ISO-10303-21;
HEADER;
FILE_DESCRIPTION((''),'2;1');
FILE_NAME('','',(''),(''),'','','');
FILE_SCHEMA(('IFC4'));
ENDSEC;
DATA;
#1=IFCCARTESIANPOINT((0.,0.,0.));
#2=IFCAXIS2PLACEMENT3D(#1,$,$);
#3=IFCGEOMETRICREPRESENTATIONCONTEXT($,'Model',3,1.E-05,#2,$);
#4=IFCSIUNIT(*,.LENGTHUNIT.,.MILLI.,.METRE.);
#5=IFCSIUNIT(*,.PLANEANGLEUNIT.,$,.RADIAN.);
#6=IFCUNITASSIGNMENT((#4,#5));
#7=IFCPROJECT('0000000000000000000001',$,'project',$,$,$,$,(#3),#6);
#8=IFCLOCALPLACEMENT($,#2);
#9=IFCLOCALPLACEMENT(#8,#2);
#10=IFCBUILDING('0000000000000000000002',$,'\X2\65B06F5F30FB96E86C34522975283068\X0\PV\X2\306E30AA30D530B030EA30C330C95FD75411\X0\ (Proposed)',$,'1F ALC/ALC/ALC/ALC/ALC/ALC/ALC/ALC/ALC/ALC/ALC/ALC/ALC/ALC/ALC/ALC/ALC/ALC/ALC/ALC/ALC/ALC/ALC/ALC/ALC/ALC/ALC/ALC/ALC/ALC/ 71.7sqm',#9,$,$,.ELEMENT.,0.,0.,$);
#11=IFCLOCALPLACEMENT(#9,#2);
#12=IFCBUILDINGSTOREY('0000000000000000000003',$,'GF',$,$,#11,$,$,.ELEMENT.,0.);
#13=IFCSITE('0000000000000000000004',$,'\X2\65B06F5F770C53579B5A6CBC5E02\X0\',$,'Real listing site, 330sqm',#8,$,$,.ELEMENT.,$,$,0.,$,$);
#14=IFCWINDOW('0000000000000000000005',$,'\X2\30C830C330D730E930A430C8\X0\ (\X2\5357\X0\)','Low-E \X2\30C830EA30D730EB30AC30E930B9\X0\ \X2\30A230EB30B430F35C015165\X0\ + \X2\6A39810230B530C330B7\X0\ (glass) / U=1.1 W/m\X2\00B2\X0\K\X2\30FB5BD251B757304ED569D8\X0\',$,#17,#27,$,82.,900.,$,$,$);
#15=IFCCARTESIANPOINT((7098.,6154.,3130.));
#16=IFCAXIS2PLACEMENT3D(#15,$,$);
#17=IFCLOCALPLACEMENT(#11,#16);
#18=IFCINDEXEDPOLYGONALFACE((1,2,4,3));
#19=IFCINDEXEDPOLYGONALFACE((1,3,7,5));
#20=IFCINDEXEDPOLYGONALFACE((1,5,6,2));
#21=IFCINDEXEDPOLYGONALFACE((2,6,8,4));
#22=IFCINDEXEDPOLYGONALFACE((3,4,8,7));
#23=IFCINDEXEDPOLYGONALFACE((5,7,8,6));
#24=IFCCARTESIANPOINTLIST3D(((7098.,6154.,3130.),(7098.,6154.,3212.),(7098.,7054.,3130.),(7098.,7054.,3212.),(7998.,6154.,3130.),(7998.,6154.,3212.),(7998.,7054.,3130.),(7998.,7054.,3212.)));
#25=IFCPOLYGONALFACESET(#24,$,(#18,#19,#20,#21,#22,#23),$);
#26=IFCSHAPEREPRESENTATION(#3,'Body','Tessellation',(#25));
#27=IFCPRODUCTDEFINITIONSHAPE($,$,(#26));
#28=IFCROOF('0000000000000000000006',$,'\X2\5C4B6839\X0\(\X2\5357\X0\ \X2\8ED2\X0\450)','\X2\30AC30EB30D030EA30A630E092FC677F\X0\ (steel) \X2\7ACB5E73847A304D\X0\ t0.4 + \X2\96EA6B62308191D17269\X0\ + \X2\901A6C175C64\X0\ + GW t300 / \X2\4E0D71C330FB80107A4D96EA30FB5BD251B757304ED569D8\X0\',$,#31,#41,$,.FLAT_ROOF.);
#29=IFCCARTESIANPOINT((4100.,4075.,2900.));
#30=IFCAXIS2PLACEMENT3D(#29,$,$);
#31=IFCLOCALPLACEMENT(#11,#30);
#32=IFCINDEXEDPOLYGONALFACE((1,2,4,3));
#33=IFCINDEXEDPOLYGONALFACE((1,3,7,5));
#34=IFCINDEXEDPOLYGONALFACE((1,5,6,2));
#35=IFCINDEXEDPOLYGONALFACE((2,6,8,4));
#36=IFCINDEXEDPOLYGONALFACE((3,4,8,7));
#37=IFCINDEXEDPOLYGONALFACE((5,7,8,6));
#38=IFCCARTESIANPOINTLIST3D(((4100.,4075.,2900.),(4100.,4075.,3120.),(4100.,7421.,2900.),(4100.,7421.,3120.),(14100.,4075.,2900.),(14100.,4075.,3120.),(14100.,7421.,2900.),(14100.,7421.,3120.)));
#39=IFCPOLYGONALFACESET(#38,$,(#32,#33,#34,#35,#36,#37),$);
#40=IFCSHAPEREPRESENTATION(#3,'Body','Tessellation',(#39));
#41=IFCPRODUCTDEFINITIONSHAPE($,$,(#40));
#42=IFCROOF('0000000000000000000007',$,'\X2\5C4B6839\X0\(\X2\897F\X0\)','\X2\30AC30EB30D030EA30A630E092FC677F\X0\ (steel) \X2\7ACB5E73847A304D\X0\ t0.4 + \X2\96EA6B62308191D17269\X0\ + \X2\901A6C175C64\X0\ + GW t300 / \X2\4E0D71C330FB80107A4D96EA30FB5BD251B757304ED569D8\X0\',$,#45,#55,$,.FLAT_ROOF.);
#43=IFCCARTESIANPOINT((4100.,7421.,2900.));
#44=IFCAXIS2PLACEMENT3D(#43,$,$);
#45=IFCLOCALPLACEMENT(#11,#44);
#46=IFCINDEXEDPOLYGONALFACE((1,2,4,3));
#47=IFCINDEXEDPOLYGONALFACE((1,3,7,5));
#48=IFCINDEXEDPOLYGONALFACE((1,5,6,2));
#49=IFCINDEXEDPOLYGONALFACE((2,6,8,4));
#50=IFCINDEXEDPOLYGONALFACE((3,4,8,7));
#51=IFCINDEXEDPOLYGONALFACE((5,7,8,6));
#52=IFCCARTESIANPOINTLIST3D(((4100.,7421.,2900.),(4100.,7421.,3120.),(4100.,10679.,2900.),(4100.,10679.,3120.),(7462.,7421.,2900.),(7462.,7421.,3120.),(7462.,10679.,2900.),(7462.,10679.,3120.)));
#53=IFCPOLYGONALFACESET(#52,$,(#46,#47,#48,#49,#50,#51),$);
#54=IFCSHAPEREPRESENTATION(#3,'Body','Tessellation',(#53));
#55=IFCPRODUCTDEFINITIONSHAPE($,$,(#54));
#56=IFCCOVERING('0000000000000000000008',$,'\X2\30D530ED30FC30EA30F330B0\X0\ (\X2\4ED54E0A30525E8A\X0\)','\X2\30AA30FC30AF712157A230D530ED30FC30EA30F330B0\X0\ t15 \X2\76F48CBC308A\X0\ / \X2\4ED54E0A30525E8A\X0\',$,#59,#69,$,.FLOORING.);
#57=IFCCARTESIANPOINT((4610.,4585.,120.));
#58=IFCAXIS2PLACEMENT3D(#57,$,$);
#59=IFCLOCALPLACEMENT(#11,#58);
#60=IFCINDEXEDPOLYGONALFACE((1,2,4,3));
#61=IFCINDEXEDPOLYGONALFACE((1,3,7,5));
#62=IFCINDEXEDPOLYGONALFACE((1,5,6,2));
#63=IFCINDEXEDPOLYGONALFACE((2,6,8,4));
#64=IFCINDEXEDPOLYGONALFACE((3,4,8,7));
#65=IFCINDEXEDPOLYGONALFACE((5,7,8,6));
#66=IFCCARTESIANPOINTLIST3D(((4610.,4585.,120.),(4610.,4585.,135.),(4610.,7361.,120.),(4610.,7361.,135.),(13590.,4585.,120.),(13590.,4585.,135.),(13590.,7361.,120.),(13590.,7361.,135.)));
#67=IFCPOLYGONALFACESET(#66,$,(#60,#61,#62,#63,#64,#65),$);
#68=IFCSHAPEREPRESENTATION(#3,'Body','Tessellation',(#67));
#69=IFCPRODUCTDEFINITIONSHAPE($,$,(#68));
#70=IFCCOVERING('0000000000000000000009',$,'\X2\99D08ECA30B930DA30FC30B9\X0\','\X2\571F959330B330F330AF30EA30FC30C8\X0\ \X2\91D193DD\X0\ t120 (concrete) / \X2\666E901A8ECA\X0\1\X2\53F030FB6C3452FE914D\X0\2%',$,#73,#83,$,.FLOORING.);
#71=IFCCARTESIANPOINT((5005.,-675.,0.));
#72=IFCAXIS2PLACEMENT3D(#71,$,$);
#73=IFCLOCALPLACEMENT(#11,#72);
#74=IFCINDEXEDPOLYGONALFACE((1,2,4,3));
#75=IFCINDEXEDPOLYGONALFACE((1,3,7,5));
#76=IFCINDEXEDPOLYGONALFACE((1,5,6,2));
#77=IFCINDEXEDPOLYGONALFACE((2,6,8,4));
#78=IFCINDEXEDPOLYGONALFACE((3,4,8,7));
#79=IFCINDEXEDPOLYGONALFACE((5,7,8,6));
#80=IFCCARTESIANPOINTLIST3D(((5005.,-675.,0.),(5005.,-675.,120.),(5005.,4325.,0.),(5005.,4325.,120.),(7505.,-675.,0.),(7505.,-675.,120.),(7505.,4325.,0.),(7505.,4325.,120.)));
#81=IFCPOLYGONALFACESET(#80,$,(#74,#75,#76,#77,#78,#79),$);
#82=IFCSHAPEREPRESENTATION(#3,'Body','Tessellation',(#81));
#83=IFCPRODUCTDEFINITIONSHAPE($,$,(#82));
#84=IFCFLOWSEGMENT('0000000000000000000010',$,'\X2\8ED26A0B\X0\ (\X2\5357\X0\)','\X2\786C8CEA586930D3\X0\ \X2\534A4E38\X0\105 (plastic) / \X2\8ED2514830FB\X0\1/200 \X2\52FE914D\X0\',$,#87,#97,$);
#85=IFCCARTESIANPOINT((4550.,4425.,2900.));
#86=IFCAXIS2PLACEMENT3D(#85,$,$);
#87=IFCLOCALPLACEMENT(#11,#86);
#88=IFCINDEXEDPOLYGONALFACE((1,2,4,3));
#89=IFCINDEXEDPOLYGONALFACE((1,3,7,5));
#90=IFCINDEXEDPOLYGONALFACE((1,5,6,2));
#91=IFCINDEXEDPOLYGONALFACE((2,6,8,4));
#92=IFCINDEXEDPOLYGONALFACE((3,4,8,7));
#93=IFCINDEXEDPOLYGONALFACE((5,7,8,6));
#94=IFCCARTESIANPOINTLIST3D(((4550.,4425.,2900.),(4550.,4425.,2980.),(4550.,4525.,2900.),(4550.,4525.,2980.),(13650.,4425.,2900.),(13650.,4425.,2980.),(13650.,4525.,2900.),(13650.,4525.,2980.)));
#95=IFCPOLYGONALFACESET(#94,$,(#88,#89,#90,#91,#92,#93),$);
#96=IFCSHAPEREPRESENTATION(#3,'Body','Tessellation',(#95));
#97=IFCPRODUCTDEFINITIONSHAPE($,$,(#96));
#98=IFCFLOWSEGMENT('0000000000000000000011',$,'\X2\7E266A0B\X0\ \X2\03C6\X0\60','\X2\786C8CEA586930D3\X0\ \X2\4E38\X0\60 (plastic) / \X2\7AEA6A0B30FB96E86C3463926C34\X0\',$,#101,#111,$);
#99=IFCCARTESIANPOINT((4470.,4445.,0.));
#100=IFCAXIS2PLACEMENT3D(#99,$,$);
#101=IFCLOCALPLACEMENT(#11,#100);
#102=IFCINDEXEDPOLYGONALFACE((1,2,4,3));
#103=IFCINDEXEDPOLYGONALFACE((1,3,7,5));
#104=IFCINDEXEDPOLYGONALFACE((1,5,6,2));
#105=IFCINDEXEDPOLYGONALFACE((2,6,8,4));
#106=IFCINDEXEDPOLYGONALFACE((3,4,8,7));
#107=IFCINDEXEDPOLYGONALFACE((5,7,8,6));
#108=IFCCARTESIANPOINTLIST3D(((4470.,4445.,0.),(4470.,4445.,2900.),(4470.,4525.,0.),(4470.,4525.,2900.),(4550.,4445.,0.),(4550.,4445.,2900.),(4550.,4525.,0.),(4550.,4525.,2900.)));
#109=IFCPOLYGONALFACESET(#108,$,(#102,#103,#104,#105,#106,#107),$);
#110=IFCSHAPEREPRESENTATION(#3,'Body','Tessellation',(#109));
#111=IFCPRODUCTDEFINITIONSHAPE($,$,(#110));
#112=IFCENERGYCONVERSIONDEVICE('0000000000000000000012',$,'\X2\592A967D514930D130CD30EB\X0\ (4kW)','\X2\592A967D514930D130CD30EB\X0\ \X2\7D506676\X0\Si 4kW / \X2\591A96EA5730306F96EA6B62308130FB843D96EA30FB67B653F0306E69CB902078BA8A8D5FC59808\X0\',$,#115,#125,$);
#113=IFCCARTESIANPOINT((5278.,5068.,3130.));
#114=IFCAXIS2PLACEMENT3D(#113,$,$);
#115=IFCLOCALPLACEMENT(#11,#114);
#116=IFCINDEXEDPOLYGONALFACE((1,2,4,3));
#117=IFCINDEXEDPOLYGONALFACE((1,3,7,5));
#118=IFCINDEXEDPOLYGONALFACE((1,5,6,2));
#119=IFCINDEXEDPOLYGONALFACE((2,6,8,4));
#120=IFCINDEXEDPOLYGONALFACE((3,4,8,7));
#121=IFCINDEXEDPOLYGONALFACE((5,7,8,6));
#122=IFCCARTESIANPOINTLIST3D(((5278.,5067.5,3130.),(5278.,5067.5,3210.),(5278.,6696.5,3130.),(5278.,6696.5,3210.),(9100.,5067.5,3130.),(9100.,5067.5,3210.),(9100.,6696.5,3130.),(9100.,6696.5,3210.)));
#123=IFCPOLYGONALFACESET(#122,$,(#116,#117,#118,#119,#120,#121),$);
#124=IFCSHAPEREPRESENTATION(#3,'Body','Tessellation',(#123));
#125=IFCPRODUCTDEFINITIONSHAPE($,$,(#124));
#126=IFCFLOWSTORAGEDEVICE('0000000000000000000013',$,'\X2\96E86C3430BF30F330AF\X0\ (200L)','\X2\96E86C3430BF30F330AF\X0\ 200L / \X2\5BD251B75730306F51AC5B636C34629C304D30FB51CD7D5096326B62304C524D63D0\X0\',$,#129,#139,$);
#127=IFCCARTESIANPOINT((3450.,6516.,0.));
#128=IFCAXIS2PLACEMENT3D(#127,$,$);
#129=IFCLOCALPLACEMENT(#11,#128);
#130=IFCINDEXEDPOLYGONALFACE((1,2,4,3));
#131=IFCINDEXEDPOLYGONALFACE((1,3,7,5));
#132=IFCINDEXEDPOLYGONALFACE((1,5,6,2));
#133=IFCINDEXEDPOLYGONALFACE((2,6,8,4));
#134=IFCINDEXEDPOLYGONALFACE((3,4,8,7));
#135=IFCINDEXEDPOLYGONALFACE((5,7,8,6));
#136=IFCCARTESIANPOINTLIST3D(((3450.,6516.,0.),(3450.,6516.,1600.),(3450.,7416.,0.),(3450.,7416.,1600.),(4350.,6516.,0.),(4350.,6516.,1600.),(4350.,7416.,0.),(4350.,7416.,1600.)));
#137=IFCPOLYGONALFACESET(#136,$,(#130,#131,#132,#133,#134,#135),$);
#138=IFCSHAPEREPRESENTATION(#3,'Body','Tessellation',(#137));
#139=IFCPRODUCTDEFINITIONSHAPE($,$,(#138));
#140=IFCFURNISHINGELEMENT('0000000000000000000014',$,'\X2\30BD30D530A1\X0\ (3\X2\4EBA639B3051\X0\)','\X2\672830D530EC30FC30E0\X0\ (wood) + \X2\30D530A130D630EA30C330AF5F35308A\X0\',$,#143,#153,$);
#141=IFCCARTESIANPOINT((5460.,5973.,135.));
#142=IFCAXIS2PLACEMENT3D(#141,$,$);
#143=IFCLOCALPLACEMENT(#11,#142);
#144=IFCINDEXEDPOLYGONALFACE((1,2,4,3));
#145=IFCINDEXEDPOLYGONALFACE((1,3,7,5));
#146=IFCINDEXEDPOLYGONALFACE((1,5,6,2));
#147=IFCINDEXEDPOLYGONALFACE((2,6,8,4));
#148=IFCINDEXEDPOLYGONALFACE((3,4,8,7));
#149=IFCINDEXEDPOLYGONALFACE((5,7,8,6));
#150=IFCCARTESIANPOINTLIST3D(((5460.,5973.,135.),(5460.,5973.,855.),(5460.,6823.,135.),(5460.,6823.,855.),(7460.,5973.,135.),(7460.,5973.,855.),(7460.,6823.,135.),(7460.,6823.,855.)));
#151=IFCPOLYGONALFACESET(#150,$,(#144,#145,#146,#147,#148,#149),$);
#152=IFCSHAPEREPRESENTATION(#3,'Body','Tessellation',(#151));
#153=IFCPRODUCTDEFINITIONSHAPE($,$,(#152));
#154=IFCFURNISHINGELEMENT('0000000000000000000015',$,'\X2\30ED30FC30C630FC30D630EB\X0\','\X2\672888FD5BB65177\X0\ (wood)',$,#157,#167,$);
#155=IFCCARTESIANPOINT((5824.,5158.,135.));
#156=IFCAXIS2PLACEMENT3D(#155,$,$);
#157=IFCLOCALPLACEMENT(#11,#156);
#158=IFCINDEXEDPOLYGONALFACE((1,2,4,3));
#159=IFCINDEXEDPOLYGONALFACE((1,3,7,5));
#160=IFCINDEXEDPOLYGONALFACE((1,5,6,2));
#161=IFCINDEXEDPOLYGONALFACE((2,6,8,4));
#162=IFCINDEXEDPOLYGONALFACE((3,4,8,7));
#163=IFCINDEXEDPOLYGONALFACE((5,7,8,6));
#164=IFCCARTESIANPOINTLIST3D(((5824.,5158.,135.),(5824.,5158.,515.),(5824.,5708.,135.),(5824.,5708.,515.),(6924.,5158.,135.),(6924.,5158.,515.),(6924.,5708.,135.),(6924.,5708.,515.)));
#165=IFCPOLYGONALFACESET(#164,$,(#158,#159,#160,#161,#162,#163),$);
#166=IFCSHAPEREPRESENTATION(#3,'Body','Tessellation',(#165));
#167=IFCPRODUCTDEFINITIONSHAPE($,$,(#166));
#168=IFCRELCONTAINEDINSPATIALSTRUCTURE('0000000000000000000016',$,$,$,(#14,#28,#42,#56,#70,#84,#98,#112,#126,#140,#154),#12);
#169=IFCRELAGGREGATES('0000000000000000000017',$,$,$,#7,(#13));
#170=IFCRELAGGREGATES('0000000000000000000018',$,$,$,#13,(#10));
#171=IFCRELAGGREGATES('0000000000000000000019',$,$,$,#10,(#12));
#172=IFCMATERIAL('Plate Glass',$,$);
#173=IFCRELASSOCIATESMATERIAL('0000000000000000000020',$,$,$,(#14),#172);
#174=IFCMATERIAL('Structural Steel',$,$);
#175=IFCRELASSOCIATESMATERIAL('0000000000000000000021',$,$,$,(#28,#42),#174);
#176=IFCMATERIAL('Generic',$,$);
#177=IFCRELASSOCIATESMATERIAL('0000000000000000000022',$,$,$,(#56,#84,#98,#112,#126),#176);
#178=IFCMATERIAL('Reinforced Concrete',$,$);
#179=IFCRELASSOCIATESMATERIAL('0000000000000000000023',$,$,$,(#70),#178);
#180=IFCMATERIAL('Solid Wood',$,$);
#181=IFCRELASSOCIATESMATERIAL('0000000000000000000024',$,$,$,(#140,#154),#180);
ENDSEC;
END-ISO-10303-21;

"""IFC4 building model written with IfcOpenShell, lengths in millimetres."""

from ifc_helpers import new_model, si_unit, frame, frame_2d, origin, place, context, project, spatial, rectangle, extrude, material, element, save


model = new_model("IFC4")

# Units and contexts
model_context = context("Model", 3, precision=1e-05, world=origin())
ifc_project = project(units=[si_unit("LENGTHUNIT", "METRE", prefix="MILLI"), si_unit("PLANEANGLEUNIT", "RADIAN")], contexts=[model_context])

# Site, building, storey
site_placement = place(None, origin())
site = spatial("IfcSite", under=ifc_project, at=site_placement, Name="新潟県南魚沼市", ObjectType="Real listing site, 330sqm", CompositionType="ELEMENT", RefElevation=0.0)
building_placement = place(site_placement, origin())
building = spatial("IfcBuilding", under=site, at=building_placement, Name="新潟・雨水利用とPVのオフグリッド志向 (Proposed)", ObjectType="1F ALC/ALC/ALC/ALC/ALC/ALC/ALC/ALC/ALC/ALC/ALC/ALC/ALC/ALC/ALC/ALC/ALC/ALC/ALC/ALC/ALC/ALC/ALC/ALC/ALC/ALC/ALC/ALC/ALC/ALC/ 71.7sqm", CompositionType="ELEMENT", ElevationOfRefHeight=0.0, ElevationOfTerrain=0.0)
storey_placement = place(building_placement, origin())
storey = spatial("IfcBuildingStorey", under=building, at=storey_placement, Name="GF", CompositionType="ELEMENT", Elevation=0.0)

# Shared definitions
ifc_material_1 = material(Name="Solid Wood")

# Shared definitions
ifc_material_2 = material(Name="Reinforced Concrete")

# Shared definitions
ifc_material_3 = material(Name="Plate Glass")

# Window
window_1_placement = place(storey_placement, frame((7098.0, 6154.0, 3130.0)))
element("IfcWindow", 1, at=window_1_placement, inside=storey, material=ifc_material_3, Name="トップライト (南)", Description="Low-E トリプルガラス アルゴン封入 + 樹脂サッシ (glass) / U=1.1 W/m²K・寒冷地仕様", OverallHeight=82.0, OverallWidth=900.0, context=model_context, shape_type="SweptSolid", body=[
    extrude(rectangle(XDim=900.0, YDim=900.0, at=frame_2d((450.0, 450.0))), frame((7098.0, 6154.0, 3130.0)), (0.0, 0.0, 1.0), 82.0),
])

# Roofs
ifc_material_4 = material(Name="Structural Steel")
roof_1_placement = place(storey_placement, frame((4100.0, 4075.0, 2900.0)))
element("IfcRoof", 2, at=roof_1_placement, inside=storey, material=ifc_material_4, Name="屋根(南 軒450)", Description="ガルバリウム鋼板 (steel) 立平葺き t0.4 + 雪止め金物 + 通気層 + GW t300 / 不燃・耐積雪・寒冷地仕様", PredefinedType="FLAT_ROOF", context=model_context, shape_type="SweptSolid", body=[
    extrude(rectangle(XDim=10000.0, YDim=3346.0, at=frame_2d((5000.0, 1673.0))), frame((4100.0, 4075.0, 2900.0)), (0.0, 0.0, 1.0), 220.0),
])
roof_2_placement = place(storey_placement, frame((4100.0, 7421.0, 2900.0)))
element("IfcRoof", 3, at=roof_2_placement, inside=storey, material=ifc_material_4, Name="屋根(西)", Description="ガルバリウム鋼板 (steel) 立平葺き t0.4 + 雪止め金物 + 通気層 + GW t300 / 不燃・耐積雪・寒冷地仕様", PredefinedType="FLAT_ROOF", context=model_context, shape_type="SweptSolid", body=[
    extrude(rectangle(XDim=3362.0, YDim=3258.0, at=frame_2d((1681.0, 1629.0))), frame((4100.0, 7421.0, 2900.0)), (0.0, 0.0, 1.0), 220.0),
])

# Coverings
ifc_material_5 = material(Name="Generic")
covering_1_placement = place(storey_placement, frame((4610.0, 4585.0, 120.0)))
element("IfcCovering", 4, at=covering_1_placement, inside=storey, material=ifc_material_5, Name="フローリング (仕上げ床)", Description="オーク無垢フローリング t15 直貼り / 仕上げ床", PredefinedType="FLOORING", context=model_context, shape_type="SweptSolid", body=[
    extrude(rectangle(XDim=8980.0, YDim=2776.0, at=frame_2d((4490.0, 1388.0))), frame((4610.0, 4585.0, 120.0)), (0.0, 0.0, 1.0), 15.0),
])
covering_2_placement = place(storey_placement, frame((5005.0, -675.0, 0.0)))
element("IfcCovering", 5, at=covering_2_placement, inside=storey, material=ifc_material_2, Name="駐車スペース", Description="土間コンクリート 金鏝 t120 (concrete) / 普通車1台・水勾配2%", PredefinedType="FLOORING", context=model_context, shape_type="SweptSolid", body=[
    extrude(rectangle(XDim=2500.0, YDim=5000.0, at=frame_2d((1250.0, 2500.0))), frame((5005.0, -675.0, 0.0)), (0.0, 0.0, 1.0), 120.0),
])

# Flow segments
flow_segment_1_placement = place(storey_placement, frame((4550.0, 4425.0, 2900.0)))
element("IfcFlowSegment", 6, at=flow_segment_1_placement, inside=storey, material=ifc_material_5, Name="軒樋 (南)", Description="硬質塩ビ 半丸105 (plastic) / 軒先・1/200 勾配", context=model_context, shape_type="SweptSolid", body=[
    extrude(rectangle(XDim=9100.0, YDim=100.0, at=frame_2d((4550.0, 50.0))), frame((4550.0, 4425.0, 2900.0)), (0.0, 0.0, 1.0), 80.0),
])
flow_segment_2_placement = place(storey_placement, frame((4470.0, 4445.0, 0.0)))
element("IfcFlowSegment", 7, at=flow_segment_2_placement, inside=storey, material=ifc_material_5, Name="縦樋 φ60", Description="硬質塩ビ 丸60 (plastic) / 竪樋・雨水排水", context=model_context, shape_type="SweptSolid", body=[
    extrude(rectangle(XDim=80.0, YDim=80.0, at=frame_2d((40.0, 40.0))), frame((4470.0, 4445.0, 0.0)), (0.0, 0.0, 1.0), 2900.0),
])

# Energy conversion device
energy_conversion_device_placement = place(storey_placement, frame((5278.0, 5068.0, 3130.0)))
element("IfcEnergyConversionDevice", 8, at=energy_conversion_device_placement, inside=storey, material=ifc_material_5, Name="太陽光パネル (4kW)", Description="太陽光パネル 結晶Si 4kW / 多雪地は雪止め・落雪・架台の構造確認必須", context=model_context, shape_type="SweptSolid", body=[
    extrude(rectangle(XDim=3822.0, YDim=1629.0, at=frame_2d((1911.0, 814.0))), frame((5278.0, 5068.0, 3130.0)), (0.0, 0.0, 1.0), 80.0),
])

# Flow storage device
flow_storage_device_placement = place(storey_placement, frame((3450.0, 6516.0, 0.0)))
element("IfcFlowStorageDevice", 9, at=flow_storage_device_placement, inside=storey, material=ifc_material_5, Name="雨水タンク (200L)", Description="雨水タンク 200L / 寒冷地は冬季水抜き・凍結防止が前提", context=model_context, shape_type="SweptSolid", body=[
    extrude(rectangle(XDim=900.0, YDim=900.0, at=frame_2d((450.0, 450.0))), frame((3450.0, 6516.0, 0.0)), (0.0, 0.0, 1.0), 1600.0),
])

# Furnishing elements
furnishing_1_placement = place(storey_placement, frame((5460.0, 5973.0, 135.0)))
element("IfcFurnishingElement", 10, at=furnishing_1_placement, inside=storey, material=ifc_material_1, Name="ソファ (3人掛け)", Description="木フレーム (wood) + ファブリック張り", context=model_context, shape_type="SweptSolid", body=[
    extrude(rectangle(XDim=2000.0, YDim=850.0, at=frame_2d((1000.0, 425.0))), frame((5460.0, 5973.0, 135.0)), (0.0, 0.0, 1.0), 720.0),
])
furnishing_2_placement = place(storey_placement, frame((5824.0, 5158.0, 135.0)))
element("IfcFurnishingElement", 11, at=furnishing_2_placement, inside=storey, material=ifc_material_1, Name="ローテーブル", Description="木製家具 (wood)", context=model_context, shape_type="SweptSolid", body=[
    extrude(rectangle(XDim=1100.0, YDim=550.0, at=frame_2d((550.0, 275.0))), frame((5824.0, 5158.0, 135.0)), (0.0, 0.0, 1.0), 380.0),
])

save(model, "model.ifc")
